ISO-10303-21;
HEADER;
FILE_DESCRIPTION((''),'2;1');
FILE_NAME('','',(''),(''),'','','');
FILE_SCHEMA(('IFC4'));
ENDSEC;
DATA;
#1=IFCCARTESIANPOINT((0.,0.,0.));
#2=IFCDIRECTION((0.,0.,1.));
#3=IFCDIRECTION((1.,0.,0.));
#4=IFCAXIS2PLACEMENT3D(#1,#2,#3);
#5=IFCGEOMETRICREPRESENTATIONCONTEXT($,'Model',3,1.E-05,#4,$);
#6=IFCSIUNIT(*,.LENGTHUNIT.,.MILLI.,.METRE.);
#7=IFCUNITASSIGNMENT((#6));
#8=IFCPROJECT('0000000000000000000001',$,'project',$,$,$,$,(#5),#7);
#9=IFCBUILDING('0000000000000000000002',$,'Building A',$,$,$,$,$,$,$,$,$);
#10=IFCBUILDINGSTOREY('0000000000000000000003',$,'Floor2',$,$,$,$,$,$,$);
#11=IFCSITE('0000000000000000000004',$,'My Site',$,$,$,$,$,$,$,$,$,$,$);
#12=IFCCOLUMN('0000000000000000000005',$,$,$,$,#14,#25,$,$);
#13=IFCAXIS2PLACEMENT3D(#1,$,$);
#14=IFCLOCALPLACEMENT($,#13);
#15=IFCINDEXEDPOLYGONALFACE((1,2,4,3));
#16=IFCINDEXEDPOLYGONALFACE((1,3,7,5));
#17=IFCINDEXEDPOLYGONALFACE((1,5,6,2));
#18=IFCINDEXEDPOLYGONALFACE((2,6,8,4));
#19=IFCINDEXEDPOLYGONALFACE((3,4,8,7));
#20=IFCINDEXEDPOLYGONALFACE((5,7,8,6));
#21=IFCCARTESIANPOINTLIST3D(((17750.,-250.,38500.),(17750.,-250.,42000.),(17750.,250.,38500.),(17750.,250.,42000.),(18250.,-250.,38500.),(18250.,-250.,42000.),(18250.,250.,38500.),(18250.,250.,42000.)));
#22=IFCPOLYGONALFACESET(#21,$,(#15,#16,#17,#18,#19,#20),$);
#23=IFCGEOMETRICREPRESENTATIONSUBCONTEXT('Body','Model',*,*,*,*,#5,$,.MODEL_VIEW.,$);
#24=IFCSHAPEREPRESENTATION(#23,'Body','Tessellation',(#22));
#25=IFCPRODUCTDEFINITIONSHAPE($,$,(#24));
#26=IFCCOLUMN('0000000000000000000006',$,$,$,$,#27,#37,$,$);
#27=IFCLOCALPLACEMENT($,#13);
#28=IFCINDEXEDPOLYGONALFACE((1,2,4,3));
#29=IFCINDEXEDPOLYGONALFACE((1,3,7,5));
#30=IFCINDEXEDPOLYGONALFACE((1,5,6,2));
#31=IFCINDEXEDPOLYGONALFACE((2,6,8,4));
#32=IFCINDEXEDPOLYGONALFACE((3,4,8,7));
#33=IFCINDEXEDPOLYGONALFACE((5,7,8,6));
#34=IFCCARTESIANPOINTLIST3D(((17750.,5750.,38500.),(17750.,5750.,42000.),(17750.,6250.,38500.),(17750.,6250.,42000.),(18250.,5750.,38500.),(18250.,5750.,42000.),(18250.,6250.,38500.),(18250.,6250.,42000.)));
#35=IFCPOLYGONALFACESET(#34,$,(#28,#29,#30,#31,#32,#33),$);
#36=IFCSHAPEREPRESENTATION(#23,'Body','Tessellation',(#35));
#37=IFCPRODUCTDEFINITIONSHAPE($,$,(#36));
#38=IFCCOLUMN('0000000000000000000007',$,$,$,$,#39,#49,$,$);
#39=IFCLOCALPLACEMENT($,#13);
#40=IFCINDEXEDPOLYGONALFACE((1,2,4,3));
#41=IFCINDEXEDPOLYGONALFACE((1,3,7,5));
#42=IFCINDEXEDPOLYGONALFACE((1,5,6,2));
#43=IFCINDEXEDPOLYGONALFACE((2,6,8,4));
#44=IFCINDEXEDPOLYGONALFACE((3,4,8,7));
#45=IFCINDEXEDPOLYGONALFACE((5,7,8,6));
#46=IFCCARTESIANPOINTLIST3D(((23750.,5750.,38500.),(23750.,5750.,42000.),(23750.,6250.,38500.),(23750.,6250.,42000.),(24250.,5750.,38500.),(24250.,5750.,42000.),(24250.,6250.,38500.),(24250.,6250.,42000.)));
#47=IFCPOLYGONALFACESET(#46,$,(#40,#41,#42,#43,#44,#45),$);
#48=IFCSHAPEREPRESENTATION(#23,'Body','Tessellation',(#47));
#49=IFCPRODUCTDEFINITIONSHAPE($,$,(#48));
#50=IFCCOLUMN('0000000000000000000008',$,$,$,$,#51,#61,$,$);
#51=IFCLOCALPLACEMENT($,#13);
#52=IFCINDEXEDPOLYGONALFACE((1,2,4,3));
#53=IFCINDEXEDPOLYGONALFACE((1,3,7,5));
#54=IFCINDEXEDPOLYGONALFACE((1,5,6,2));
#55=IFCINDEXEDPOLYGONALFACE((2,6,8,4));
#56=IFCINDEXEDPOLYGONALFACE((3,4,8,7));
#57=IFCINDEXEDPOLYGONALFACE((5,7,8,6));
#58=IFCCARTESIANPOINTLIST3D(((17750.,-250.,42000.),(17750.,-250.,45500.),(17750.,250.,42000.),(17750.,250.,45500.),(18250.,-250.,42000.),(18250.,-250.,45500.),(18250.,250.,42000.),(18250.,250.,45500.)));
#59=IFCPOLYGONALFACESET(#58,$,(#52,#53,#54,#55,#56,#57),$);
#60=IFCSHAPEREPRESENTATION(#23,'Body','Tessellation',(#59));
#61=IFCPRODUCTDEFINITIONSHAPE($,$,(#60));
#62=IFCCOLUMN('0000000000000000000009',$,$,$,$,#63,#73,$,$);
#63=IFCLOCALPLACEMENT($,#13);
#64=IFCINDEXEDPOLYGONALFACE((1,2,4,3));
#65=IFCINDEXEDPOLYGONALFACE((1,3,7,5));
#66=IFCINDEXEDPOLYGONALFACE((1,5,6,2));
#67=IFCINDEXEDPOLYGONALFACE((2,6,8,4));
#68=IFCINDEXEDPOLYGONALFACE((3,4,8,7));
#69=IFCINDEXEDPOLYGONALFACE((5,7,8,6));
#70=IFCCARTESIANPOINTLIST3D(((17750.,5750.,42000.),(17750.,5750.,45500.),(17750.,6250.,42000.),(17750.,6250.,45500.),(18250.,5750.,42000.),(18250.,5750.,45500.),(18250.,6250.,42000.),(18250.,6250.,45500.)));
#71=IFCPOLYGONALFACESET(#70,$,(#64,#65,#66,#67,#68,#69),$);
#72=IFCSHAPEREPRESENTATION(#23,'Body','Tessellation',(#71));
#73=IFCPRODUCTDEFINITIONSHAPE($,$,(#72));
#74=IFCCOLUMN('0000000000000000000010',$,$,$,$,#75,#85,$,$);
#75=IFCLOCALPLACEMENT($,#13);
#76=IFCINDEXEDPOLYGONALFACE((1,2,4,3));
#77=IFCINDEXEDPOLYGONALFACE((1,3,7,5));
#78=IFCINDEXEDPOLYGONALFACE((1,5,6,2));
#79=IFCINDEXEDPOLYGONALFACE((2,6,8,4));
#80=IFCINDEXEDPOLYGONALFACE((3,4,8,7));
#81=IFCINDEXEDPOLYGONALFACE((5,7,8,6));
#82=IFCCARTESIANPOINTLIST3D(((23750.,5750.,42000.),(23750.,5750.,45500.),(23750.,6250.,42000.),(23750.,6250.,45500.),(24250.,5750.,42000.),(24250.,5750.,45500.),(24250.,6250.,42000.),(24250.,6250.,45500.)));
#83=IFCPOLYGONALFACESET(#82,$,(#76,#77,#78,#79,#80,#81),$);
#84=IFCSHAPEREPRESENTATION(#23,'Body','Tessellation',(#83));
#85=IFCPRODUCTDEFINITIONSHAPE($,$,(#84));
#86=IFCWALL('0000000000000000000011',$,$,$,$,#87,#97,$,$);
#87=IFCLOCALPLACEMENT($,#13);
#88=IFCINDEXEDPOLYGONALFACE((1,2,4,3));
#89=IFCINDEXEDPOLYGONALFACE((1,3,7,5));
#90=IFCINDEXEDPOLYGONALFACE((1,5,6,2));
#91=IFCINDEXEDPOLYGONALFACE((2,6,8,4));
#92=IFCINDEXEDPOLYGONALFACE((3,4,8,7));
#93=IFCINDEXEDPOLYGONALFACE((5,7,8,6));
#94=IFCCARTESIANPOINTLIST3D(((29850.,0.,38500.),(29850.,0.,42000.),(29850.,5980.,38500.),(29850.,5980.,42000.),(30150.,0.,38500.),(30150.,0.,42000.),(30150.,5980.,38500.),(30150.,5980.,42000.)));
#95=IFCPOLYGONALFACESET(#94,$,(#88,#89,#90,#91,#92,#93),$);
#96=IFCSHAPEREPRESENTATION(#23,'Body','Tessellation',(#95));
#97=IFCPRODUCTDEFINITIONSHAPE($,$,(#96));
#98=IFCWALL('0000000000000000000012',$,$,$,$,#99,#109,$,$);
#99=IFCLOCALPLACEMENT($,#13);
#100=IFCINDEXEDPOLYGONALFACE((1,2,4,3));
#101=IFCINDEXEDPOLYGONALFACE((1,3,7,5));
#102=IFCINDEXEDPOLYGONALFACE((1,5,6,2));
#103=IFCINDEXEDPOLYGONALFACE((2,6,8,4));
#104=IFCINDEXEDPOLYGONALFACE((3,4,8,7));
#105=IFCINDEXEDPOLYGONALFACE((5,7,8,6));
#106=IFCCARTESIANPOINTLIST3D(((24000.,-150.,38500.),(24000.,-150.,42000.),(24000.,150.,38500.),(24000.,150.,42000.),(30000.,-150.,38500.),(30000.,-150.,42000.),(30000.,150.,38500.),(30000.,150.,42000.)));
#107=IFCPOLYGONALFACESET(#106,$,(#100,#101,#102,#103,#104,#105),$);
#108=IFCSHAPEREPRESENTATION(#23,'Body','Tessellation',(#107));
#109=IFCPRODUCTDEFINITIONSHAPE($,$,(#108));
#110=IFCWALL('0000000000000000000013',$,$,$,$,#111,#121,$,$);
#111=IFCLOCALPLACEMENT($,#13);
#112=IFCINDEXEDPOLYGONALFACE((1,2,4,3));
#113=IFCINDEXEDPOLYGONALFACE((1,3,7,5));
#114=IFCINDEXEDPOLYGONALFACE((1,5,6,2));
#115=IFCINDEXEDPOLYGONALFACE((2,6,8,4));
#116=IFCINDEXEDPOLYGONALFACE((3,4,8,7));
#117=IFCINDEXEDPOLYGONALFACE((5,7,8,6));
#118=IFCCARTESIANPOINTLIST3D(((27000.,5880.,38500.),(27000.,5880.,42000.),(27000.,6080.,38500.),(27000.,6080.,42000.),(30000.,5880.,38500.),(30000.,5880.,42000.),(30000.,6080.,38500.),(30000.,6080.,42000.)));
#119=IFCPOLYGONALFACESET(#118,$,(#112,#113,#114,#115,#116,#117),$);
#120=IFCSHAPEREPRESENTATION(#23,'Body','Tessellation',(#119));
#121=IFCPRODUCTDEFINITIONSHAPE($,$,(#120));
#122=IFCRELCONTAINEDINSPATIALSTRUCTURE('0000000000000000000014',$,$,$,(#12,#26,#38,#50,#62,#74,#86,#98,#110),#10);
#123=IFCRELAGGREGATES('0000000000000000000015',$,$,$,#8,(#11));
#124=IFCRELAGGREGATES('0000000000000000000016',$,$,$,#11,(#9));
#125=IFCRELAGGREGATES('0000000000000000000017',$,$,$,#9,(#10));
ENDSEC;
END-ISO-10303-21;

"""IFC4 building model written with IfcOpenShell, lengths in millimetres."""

from ifc_helpers import new_model, si_unit, frame, origin_with_axes, place, context, subcontext, project, spatial, line, indexed_curve, outline, extrude, element, save


model = new_model("IFC4")

# Units and contexts
model_context = context("Model", 3, precision=1e-05, world=origin_with_axes())
body_context = subcontext(model_context, "Body", "Model", "MODEL_VIEW")
ifc_project = project(units=[si_unit("LENGTHUNIT", "METRE", prefix="MILLI")], contexts=[model_context])

# Site, building, storey
site = spatial("IfcSite", under=ifc_project, Name="My Site")
building = spatial("IfcBuilding", under=site, Name="Building A")
storey = spatial("IfcBuildingStorey", under=building, Name="Floor2")

# Columns
for number, where, z_axis, x_axis in (
    (1, (18000.0, 0.0, 38500.0), (0.0, 0.0, 1.0), (1.0, 0.0, 0.0)),
    (2, (18000.0, 6000.0, 38500.0), (0.0, 0.0, 1.0), (1.0, 0.0, 0.0)),
    (3, (24000.0, 6000.0, 38500.0), (0.0, 0.0, 1.0), (1.0, 0.0, 0.0)),
    (4, (18000.0, 0.0, 42000.0), (0.0, 0.0, 1.0), (1.0, 0.0, 0.0)),
    (5, (18000.0, 6000.0, 42000.0), (0.0, 0.0, 1.0), (1.0, 0.0, 0.0)),
    (6, (24000.0, 6000.0, 42000.0), (0.0, 0.0, 1.0), (1.0, 0.0, 0.0)),
):
    element("IfcColumn", number, at=place(None, frame(where, z_axis=z_axis, x_axis=x_axis)), inside=storey, context=body_context, shape_type="SweptSolid", body=[
        extrude(outline(indexed_curve([(-250.0, -250.0), (250.0, -250.0), (250.0, 250.0), (-250.0, 250.0)], segments=[line(1, 2, 3, 4, 1)])), origin_with_axes(), (0.0, 0.0, 1.0), 3500.0),
    ])

# Walls
wall_1_placement = place(None, frame((29850.0, 5980.0, 38500.0), z_axis=(0.0, 0.0, 1.0), x_axis=(0.0, -1.0, 0.0)))
element("IfcWall", 7, at=wall_1_placement, inside=storey, context=body_context, shape_type="SweptSolid", body=[
    extrude(outline(indexed_curve([(0.0, 0.0), (0.0, 300.0), (5980.0, 300.0), (5980.0, 0.0), (0.0, 0.0)], self_intersect=False)), origin_with_axes(), (0.0, 0.0, 1.0), 3500.0),
])
wall_2_placement = place(None, frame((30000.0, 150.0, 38500.0), z_axis=(0.0, 0.0, 1.0), x_axis=(-1.0, 0.0, 0.0)))
element("IfcWall", 8, at=wall_2_placement, inside=storey, context=body_context, shape_type="SweptSolid", body=[
    extrude(outline(indexed_curve([(0.0, 0.0), (0.0, 300.0), (6000.0, 300.0), (6000.0, 0.0), (0.0, 0.0)], self_intersect=False)), origin_with_axes(), (0.0, 0.0, 1.0), 3500.0),
])
wall_3_placement = place(None, frame((27000.0, 5880.0, 38500.0), z_axis=(0.0, 0.0, 1.0), x_axis=(1.0, 0.0, 0.0)))
element("IfcWall", 9, at=wall_3_placement, inside=storey, context=body_context, shape_type="SweptSolid", body=[
    extrude(outline(indexed_curve([(0.0, 0.0), (0.0, 200.0), (3000.0, 200.0), (3000.0, 0.0), (0.0, 0.0)], self_intersect=False)), origin_with_axes(), (0.0, 0.0, 1.0), 3500.0),
])

save(model, "model.ifc")
